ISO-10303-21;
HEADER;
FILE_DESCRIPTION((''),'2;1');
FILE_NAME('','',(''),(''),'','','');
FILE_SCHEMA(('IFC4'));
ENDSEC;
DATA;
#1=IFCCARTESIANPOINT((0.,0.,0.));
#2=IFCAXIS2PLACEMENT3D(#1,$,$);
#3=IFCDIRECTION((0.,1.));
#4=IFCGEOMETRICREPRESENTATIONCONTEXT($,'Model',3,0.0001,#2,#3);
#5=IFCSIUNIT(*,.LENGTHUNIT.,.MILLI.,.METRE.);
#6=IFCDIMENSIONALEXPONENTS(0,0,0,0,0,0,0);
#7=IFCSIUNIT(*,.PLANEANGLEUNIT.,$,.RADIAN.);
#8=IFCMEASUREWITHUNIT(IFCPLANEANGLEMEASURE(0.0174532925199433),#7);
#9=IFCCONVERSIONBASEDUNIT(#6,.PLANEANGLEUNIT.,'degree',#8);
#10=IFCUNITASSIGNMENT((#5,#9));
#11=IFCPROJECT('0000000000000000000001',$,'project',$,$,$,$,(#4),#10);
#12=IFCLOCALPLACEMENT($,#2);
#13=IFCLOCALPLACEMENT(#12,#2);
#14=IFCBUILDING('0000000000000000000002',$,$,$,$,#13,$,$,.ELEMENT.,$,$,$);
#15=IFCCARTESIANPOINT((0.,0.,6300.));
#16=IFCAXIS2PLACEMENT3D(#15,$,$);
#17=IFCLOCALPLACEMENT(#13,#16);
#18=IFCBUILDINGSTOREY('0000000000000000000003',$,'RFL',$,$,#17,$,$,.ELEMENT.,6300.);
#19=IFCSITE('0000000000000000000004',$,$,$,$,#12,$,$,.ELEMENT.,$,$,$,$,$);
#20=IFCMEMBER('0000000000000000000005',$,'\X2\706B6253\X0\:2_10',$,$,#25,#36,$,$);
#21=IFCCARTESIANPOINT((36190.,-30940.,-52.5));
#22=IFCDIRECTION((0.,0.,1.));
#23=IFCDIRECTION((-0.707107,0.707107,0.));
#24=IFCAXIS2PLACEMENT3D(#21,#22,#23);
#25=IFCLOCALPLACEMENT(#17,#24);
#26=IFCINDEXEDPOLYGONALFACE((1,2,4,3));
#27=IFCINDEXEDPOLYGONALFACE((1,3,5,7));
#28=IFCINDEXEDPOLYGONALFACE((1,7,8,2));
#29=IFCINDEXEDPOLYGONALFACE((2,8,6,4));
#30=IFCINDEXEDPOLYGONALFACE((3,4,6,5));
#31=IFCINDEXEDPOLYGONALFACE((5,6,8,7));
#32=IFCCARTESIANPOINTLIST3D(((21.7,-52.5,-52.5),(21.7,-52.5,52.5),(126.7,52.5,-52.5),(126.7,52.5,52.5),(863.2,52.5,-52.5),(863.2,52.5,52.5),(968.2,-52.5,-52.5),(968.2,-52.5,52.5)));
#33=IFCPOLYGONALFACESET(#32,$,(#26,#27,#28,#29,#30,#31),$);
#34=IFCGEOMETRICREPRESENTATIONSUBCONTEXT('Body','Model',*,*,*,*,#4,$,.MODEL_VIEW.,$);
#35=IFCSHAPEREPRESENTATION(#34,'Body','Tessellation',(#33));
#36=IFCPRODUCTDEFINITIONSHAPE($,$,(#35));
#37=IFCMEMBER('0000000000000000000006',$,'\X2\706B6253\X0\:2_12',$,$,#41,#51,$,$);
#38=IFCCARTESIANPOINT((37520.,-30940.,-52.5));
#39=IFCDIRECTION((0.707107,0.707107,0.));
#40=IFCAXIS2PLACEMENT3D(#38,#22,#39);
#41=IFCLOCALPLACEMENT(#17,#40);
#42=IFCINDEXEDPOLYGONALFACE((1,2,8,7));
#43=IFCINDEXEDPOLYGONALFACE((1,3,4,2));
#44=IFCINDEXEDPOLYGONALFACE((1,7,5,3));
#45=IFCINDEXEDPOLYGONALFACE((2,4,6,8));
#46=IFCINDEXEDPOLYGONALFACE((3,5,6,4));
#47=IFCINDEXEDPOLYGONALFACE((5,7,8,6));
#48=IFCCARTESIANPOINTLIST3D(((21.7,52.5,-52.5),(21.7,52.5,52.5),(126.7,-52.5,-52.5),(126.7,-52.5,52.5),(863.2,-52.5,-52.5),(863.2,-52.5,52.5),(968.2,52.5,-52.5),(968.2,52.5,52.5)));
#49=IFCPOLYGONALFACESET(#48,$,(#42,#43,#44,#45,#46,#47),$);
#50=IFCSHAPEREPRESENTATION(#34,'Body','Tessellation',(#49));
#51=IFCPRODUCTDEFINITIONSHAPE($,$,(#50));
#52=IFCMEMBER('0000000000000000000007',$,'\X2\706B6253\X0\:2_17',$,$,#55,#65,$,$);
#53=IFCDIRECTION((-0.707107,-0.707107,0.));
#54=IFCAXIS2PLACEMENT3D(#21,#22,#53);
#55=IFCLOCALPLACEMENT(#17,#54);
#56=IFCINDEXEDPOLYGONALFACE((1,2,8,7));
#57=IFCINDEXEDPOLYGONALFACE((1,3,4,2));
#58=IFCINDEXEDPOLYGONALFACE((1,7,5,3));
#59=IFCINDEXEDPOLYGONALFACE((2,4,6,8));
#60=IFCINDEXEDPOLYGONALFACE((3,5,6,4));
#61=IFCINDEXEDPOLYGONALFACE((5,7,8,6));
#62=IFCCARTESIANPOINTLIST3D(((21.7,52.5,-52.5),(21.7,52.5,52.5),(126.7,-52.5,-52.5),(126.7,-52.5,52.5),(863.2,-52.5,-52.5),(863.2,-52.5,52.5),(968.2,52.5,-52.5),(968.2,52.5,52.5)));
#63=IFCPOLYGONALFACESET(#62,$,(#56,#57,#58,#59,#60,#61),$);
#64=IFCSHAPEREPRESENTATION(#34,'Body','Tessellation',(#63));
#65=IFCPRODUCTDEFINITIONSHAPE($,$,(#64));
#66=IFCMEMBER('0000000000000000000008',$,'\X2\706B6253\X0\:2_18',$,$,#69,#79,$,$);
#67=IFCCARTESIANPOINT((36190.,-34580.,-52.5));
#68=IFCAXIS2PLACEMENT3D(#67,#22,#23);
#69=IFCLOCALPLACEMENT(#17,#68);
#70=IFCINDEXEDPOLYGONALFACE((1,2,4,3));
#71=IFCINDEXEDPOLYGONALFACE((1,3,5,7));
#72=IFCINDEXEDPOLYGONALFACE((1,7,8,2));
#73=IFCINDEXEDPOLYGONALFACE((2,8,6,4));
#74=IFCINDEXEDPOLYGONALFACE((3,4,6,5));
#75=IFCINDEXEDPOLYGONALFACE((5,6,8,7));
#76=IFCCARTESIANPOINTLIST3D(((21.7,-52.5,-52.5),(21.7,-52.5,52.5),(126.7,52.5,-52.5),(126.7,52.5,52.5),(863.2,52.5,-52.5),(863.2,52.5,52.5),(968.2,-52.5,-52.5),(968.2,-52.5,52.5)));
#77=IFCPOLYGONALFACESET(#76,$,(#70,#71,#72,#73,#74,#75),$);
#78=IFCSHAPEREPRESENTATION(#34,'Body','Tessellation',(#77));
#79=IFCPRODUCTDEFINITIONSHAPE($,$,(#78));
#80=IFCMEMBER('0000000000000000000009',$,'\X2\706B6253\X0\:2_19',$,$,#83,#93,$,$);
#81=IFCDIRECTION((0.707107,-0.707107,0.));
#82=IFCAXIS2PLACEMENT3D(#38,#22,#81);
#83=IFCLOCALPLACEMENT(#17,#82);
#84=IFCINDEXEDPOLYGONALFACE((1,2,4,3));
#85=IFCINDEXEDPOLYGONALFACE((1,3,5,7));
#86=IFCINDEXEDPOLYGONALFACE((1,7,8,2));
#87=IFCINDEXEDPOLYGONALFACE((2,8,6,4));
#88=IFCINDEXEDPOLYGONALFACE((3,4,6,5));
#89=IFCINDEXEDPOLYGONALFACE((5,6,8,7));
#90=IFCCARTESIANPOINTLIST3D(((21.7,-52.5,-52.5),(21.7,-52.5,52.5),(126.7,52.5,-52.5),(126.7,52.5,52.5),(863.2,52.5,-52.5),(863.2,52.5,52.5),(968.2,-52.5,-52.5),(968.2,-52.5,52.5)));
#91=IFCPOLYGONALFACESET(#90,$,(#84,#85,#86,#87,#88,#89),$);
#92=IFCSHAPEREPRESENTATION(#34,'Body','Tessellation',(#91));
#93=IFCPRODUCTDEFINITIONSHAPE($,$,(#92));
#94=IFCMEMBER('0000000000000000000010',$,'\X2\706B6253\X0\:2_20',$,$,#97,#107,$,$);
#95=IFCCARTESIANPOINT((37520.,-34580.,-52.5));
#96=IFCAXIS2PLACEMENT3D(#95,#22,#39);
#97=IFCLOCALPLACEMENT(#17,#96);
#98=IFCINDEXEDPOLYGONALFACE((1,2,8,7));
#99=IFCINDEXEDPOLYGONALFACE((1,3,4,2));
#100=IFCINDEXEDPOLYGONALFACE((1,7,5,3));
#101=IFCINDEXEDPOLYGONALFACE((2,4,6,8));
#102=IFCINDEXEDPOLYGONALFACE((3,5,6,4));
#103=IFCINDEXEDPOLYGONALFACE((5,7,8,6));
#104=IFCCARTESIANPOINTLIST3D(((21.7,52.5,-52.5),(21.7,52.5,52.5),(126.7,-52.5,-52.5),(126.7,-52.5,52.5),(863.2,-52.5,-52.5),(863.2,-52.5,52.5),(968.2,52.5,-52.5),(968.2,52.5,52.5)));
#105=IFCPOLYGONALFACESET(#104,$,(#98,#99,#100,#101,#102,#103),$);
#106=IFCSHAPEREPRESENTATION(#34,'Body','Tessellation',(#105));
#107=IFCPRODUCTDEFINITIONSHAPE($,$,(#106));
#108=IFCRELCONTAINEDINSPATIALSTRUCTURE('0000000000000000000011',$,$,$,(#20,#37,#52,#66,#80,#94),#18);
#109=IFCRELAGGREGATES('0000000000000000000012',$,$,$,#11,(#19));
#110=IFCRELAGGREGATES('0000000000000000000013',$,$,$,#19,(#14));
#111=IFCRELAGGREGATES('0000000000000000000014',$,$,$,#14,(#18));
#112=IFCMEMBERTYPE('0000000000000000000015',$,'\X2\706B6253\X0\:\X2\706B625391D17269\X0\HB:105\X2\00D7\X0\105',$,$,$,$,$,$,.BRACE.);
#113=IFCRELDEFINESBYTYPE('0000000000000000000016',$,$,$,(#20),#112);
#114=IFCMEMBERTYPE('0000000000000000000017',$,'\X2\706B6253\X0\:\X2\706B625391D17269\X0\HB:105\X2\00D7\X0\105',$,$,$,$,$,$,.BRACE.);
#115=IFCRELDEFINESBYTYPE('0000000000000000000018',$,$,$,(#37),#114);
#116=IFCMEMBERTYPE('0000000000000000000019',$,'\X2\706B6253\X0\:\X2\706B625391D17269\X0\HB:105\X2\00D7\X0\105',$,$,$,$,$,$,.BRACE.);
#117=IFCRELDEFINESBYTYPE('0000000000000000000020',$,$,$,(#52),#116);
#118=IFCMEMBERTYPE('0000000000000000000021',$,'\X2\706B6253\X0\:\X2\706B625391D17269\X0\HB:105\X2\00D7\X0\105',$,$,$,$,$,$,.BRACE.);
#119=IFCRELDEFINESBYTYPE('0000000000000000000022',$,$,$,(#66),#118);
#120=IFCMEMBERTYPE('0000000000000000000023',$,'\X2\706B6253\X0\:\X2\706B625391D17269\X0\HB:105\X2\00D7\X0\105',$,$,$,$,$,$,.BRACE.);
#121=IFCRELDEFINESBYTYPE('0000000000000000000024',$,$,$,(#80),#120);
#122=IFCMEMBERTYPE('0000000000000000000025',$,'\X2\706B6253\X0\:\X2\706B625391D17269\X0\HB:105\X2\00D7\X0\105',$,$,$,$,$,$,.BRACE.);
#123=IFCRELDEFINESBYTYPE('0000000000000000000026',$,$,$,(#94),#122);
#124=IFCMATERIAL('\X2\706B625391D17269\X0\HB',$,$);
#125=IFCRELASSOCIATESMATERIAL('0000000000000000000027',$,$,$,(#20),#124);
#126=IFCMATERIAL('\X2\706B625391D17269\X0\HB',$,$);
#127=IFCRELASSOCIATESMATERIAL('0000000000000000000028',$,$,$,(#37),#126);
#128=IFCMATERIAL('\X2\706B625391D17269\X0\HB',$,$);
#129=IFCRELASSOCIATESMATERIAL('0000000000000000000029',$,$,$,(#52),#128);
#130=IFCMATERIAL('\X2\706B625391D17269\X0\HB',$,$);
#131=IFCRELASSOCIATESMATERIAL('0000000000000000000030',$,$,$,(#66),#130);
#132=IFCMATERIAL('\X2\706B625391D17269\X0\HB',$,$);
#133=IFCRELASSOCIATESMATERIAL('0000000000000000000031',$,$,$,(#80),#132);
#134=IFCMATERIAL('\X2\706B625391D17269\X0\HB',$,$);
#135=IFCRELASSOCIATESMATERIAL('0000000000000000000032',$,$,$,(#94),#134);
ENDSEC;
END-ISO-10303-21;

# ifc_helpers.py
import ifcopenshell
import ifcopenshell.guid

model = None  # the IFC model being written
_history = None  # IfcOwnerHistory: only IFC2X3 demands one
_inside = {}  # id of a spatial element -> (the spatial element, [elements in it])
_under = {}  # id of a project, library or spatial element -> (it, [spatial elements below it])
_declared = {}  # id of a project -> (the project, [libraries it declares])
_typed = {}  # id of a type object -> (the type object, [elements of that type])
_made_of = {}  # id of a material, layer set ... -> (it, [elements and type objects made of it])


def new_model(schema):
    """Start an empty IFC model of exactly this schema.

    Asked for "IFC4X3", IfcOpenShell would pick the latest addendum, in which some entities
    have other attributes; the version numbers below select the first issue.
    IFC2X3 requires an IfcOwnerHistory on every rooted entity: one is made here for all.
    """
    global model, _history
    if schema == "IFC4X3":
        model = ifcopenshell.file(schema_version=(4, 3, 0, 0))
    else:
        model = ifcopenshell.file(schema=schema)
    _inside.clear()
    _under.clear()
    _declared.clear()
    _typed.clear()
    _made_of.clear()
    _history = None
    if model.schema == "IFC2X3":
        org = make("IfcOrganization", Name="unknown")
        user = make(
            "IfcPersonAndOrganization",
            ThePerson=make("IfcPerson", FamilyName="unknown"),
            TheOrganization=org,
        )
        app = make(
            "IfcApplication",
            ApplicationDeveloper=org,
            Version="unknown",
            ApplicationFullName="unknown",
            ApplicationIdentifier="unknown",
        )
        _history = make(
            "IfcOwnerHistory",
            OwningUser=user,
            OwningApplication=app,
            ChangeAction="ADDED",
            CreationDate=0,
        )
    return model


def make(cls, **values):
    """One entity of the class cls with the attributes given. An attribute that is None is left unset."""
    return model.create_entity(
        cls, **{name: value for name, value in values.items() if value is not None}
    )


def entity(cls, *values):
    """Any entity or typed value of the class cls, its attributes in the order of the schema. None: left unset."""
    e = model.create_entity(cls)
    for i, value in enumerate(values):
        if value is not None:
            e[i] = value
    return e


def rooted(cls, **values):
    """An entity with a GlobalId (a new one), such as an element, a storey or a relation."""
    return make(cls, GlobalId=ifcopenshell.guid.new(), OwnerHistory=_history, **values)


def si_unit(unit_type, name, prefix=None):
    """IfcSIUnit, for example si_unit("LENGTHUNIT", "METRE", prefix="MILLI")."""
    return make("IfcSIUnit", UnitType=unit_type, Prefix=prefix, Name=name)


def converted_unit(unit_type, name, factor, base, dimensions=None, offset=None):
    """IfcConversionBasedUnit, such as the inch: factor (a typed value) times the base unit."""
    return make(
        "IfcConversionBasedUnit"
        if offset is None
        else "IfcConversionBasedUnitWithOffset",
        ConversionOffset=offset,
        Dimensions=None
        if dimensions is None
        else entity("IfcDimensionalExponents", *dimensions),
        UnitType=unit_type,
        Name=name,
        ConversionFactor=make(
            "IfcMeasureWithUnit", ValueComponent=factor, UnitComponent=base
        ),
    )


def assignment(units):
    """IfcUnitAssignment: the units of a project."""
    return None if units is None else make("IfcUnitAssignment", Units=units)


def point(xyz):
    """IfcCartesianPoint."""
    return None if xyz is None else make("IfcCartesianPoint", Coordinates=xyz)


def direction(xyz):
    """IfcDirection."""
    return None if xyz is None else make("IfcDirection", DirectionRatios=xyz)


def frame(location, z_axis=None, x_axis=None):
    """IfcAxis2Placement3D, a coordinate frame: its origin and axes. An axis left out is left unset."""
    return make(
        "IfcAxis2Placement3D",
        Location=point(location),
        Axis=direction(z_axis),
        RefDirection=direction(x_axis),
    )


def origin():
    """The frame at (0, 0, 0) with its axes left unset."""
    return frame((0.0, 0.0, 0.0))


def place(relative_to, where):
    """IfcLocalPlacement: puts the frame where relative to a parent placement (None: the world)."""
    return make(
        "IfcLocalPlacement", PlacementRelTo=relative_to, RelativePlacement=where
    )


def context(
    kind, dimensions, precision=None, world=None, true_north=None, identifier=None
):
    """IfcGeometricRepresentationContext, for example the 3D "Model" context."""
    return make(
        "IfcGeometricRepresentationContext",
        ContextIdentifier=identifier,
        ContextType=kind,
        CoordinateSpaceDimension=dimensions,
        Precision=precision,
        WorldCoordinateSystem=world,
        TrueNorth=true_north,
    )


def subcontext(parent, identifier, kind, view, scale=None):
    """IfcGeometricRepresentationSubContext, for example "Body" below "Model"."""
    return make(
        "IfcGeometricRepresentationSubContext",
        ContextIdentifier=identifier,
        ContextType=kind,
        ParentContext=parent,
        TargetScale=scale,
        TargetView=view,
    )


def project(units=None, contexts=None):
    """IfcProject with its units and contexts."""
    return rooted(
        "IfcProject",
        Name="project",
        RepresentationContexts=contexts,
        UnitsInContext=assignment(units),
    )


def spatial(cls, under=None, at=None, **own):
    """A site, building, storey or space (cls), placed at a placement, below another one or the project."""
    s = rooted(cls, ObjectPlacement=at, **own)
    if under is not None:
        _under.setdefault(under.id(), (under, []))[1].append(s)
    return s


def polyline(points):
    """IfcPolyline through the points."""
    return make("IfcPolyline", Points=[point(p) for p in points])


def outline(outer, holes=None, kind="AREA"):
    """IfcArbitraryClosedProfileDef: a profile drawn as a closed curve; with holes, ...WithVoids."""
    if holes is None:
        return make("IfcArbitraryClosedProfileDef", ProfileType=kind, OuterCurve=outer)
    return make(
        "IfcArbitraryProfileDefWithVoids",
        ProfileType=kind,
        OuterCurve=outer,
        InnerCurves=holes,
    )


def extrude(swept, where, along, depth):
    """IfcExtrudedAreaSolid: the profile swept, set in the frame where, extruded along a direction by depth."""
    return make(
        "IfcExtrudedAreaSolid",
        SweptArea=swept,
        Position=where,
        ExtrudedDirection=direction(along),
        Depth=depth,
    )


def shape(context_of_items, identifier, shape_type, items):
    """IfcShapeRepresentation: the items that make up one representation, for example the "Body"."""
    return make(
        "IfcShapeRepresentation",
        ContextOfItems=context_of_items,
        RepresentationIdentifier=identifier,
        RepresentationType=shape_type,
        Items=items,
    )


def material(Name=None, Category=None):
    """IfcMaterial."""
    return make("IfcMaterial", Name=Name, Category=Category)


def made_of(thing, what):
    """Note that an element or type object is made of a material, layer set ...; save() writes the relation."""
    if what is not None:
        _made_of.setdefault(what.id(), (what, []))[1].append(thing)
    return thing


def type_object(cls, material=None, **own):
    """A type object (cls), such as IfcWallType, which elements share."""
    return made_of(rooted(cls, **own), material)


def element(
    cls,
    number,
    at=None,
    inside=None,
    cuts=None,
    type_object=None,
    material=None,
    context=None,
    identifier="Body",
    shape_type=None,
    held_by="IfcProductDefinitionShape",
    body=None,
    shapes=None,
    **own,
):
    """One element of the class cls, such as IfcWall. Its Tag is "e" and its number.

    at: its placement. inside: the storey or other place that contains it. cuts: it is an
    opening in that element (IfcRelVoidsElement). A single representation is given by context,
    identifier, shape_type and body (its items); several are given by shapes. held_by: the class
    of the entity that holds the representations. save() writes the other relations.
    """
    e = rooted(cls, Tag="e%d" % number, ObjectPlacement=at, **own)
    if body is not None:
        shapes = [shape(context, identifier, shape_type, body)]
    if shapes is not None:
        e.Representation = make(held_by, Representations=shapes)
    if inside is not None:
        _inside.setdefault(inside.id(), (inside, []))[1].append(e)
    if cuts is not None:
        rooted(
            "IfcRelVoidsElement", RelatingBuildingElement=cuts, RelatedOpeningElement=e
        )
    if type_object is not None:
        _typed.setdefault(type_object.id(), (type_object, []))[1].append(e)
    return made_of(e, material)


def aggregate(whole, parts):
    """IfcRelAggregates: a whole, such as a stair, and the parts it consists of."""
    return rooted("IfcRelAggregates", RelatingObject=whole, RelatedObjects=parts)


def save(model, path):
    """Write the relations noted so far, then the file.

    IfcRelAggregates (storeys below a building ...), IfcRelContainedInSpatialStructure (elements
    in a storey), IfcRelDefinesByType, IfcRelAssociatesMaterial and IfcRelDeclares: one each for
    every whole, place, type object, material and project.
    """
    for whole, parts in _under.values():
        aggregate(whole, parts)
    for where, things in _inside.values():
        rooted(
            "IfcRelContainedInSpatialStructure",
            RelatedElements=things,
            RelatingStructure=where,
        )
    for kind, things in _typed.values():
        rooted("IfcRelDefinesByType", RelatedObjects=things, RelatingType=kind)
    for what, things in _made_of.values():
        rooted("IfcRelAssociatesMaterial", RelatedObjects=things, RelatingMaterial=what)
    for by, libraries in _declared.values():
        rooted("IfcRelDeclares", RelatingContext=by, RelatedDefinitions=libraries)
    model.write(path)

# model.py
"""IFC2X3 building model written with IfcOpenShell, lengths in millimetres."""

from ifc_helpers import new_model, entity, si_unit, converted_unit, direction, frame, origin, place, context, subcontext, project, spatial, polyline, outline, extrude, material, type_object, element, save


model = new_model("IFC2X3")

# Units and contexts
model_context = context("Model", 3, precision=0.0001, world=origin(), true_north=direction((0.0, 1.0)))
body_context = subcontext(model_context, "Body", "Model", "MODEL_VIEW")
ifc_project = project(units=[si_unit("LENGTHUNIT", "METRE", prefix="MILLI"), converted_unit("PLANEANGLEUNIT", "degree", entity("IfcPlaneAngleMeasure", 0.0174532925199433), si_unit("PLANEANGLEUNIT", "RADIAN"), dimensions=[0, 0, 0, 0, 0, 0, 0])], contexts=[model_context])

# Site, building, storey
site_placement = place(None, origin())
site = spatial("IfcSite", under=ifc_project, at=site_placement, CompositionType="ELEMENT")
building_placement = place(site_placement, origin())
building = spatial("IfcBuilding", under=site, at=building_placement, CompositionType="ELEMENT")
storey_placement = place(building_placement, frame((0.0, 0.0, 6300.0)))
storey = spatial("IfcBuildingStorey", under=building, at=storey_placement, Name="RFL", CompositionType="ELEMENT", Elevation=6300.0)

# Members
ifc_material_1 = material(Name="火打金物HB")
member_type_1 = type_object("IfcMemberType", Name="火打:火打金物HB:105×105", PredefinedType="BRACE")
member_1_placement = place(storey_placement, frame((36190.0, -30940.0, -52.5), z_axis=(0.0, 0.0, 1.0), x_axis=(-0.707107, 0.707107, 0.0)))
element("IfcMember", 1, at=member_1_placement, inside=storey, type_object=member_type_1, material=ifc_material_1, Name="火打:2_10", context=body_context, shape_type="SweptSolid", body=[
    extrude(outline(polyline([(21.7, -52.5, 0.0), (126.7, 52.5, 0.0), (863.2, 52.5, 0.0), (968.2, -52.5, 0.0), (21.7, -52.5, 0.0)])), frame((0.0, 0.0, -52.5), z_axis=(0.0, 0.0, 1.0), x_axis=(1.0, 0.0, 0.0)), (0.0, 0.0, 1.0), 105.0),
])
ifc_material_2 = material(Name="火打金物HB")
member_type_2 = type_object("IfcMemberType", Name="火打:火打金物HB:105×105", PredefinedType="BRACE")
member_2_placement = place(storey_placement, frame((37520.0, -30940.0, -52.5), z_axis=(0.0, 0.0, 1.0), x_axis=(0.707107, 0.707107, 0.0)))
element("IfcMember", 2, at=member_2_placement, inside=storey, type_object=member_type_2, material=ifc_material_2, Name="火打:2_12", context=body_context, shape_type="SweptSolid", body=[
    extrude(outline(polyline([(126.7, -52.5, 0.0), (21.7, 52.5, 0.0), (968.2, 52.5, 0.0), (863.2, -52.5, 0.0), (126.7, -52.5, 0.0)])), frame((0.0, 0.0, -52.5), z_axis=(0.0, 0.0, 1.0), x_axis=(1.0, 0.0, 0.0)), (0.0, 0.0, 1.0), 105.0),
])
ifc_material_3 = material(Name="火打金物HB")
member_type_3 = type_object("IfcMemberType", Name="火打:火打金物HB:105×105", PredefinedType="BRACE")
member_3_placement = place(storey_placement, frame((36190.0, -30940.0, -52.5), z_axis=(0.0, 0.0, 1.0), x_axis=(-0.707107, -0.707107, 0.0)))
element("IfcMember", 3, at=member_3_placement, inside=storey, type_object=member_type_3, material=ifc_material_3, Name="火打:2_17", context=body_context, shape_type="SweptSolid", body=[
    extrude(outline(polyline([(126.7, -52.5, 0.0), (21.7, 52.5, 0.0), (968.2, 52.5, 0.0), (863.2, -52.5, 0.0), (126.7, -52.5, 0.0)])), frame((0.0, 0.0, -52.5), z_axis=(0.0, 0.0, 1.0), x_axis=(1.0, 0.0, 0.0)), (0.0, 0.0, 1.0), 105.0),
])
ifc_material_4 = material(Name="火打金物HB")
member_type_4 = type_object("IfcMemberType", Name="火打:火打金物HB:105×105", PredefinedType="BRACE")
member_4_placement = place(storey_placement, frame((36190.0, -34580.0, -52.5), z_axis=(0.0, 0.0, 1.0), x_axis=(-0.707107, 0.707107, 0.0)))
element("IfcMember", 4, at=member_4_placement, inside=storey, type_object=member_type_4, material=ifc_material_4, Name="火打:2_18", context=body_context, shape_type="SweptSolid", body=[
    extrude(outline(polyline([(21.7, -52.5, 0.0), (126.7, 52.5, 0.0), (863.2, 52.5, 0.0), (968.2, -52.5, 0.0), (21.7, -52.5, 0.0)])), frame((0.0, 0.0, -52.5), z_axis=(0.0, 0.0, 1.0), x_axis=(1.0, 0.0, 0.0)), (0.0, 0.0, 1.0), 105.0),
])
ifc_material_5 = material(Name="火打金物HB")
member_type_5 = type_object("IfcMemberType", Name="火打:火打金物HB:105×105", PredefinedType="BRACE")
member_5_placement = place(storey_placement, frame((37520.0, -30940.0, -52.5), z_axis=(0.0, 0.0, 1.0), x_axis=(0.707107, -0.707107, 0.0)))
element("IfcMember", 5, at=member_5_placement, inside=storey, type_object=member_type_5, material=ifc_material_5, Name="火打:2_19", context=body_context, shape_type="SweptSolid", body=[
    extrude(outline(polyline([(21.7, -52.5, 0.0), (126.7, 52.5, 0.0), (863.2, 52.5, 0.0), (968.2, -52.5, 0.0), (21.7, -52.5, 0.0)])), frame((0.0, 0.0, -52.5), z_axis=(0.0, 0.0, 1.0), x_axis=(1.0, 0.0, 0.0)), (0.0, 0.0, 1.0), 105.0),
])
ifc_material_6 = material(Name="火打金物HB")
member_type_6 = type_object("IfcMemberType", Name="火打:火打金物HB:105×105", PredefinedType="BRACE")
member_6_placement = place(storey_placement, frame((37520.0, -34580.0, -52.5), z_axis=(0.0, 0.0, 1.0), x_axis=(0.707107, 0.707107, 0.0)))
element("IfcMember", 6, at=member_6_placement, inside=storey, type_object=member_type_6, material=ifc_material_6, Name="火打:2_20", context=body_context, shape_type="SweptSolid", body=[
    extrude(outline(polyline([(126.7, -52.5, 0.0), (21.7, 52.5, 0.0), (968.2, 52.5, 0.0), (863.2, -52.5, 0.0), (126.7, -52.5, 0.0)])), frame((0.0, 0.0, -52.5), z_axis=(0.0, 0.0, 1.0), x_axis=(1.0, 0.0, 0.0)), (0.0, 0.0, 1.0), 105.0),
])

save(model, "model.ifc")
